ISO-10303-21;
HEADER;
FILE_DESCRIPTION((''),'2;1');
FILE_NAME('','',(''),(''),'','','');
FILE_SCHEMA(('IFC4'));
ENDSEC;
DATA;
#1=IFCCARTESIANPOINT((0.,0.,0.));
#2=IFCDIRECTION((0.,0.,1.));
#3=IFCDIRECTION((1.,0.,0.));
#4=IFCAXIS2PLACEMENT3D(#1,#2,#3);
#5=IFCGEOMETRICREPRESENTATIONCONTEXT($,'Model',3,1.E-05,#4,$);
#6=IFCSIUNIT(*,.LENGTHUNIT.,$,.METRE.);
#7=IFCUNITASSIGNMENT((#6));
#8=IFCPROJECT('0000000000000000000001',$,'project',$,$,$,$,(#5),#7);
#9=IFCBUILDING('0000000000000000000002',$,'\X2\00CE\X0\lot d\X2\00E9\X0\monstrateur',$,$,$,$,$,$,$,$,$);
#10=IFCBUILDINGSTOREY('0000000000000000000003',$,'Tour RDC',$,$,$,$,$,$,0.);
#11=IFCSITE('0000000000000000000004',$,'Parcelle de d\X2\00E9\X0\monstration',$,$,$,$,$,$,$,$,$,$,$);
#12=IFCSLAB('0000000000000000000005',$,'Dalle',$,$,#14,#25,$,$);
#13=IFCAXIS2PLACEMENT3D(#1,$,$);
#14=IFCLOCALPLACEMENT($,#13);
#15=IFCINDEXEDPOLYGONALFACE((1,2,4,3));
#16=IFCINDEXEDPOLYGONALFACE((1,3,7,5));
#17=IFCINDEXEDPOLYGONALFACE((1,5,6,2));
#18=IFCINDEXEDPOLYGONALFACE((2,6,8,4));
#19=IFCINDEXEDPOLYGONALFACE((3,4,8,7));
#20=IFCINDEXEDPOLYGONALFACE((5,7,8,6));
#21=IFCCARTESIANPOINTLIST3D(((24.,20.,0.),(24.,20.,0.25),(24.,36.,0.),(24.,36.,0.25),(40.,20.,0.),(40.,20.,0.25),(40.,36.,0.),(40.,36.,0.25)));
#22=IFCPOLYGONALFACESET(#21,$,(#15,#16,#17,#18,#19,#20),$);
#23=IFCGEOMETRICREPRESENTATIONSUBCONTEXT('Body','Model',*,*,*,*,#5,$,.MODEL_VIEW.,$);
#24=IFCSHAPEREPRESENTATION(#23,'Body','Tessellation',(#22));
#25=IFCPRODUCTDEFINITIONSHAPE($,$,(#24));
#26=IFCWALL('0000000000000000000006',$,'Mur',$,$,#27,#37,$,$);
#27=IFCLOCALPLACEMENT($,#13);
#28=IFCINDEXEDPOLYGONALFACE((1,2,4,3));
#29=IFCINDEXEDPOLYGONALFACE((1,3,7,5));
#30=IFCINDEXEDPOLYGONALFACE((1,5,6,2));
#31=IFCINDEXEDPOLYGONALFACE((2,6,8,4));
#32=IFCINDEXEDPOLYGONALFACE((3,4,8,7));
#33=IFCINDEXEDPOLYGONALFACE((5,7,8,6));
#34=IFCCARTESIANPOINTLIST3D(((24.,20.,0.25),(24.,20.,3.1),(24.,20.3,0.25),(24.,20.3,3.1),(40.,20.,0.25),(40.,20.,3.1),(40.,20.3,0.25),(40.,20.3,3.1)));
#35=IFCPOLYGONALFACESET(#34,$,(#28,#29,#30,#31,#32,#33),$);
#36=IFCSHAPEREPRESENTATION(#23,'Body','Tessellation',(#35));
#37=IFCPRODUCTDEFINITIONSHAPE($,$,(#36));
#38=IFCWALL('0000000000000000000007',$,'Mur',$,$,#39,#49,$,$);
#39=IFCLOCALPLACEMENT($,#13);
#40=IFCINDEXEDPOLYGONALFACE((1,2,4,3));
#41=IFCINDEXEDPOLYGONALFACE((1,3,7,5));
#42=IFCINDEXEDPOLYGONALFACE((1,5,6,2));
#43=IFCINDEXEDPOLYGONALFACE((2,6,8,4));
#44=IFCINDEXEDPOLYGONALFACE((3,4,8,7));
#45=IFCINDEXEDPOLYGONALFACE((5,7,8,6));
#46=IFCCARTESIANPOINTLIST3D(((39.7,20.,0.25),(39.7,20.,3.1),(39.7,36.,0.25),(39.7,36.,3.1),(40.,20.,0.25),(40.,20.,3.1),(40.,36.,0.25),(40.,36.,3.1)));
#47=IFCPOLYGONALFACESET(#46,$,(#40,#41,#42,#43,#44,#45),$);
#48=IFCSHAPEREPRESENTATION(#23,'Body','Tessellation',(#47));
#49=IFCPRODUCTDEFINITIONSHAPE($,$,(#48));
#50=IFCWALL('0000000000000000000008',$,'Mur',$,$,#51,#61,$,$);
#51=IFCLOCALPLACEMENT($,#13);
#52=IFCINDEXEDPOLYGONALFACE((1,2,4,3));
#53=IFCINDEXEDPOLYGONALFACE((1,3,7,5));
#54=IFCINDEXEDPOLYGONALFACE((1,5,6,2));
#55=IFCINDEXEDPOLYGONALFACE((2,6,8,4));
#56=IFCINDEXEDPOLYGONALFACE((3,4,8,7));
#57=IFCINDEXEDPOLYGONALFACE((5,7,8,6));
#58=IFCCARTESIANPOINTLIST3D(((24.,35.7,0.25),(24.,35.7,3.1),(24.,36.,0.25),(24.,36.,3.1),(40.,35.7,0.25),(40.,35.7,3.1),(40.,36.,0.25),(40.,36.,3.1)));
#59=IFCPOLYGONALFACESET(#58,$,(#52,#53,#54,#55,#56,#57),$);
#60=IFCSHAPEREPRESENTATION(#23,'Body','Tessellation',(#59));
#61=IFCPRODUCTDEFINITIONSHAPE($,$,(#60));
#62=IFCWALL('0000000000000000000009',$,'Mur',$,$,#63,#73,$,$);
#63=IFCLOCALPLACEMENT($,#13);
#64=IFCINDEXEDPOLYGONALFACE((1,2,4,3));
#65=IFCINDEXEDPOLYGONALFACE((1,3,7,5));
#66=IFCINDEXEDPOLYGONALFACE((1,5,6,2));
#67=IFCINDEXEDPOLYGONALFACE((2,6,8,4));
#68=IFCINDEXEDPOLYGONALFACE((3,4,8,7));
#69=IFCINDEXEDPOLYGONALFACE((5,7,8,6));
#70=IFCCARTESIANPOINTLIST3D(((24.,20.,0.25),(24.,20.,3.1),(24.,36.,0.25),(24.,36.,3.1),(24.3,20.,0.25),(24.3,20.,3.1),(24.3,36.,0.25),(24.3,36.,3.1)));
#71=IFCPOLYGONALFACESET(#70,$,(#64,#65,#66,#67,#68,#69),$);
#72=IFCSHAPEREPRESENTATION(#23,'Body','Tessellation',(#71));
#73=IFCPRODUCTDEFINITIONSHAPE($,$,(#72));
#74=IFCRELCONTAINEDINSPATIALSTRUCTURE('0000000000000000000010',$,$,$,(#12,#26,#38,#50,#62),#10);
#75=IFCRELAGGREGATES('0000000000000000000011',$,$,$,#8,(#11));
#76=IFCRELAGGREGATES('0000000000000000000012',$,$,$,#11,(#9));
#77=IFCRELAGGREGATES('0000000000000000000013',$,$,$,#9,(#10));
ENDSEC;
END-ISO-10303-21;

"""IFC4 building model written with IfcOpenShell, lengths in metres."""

from ifc_helpers import new_model, si_unit, frame, origin_with_axes, place, context, subcontext, project, spatial, indexed_curve, outline, extrude, element, save


model = new_model("IFC4")

# Units and contexts
model_context = context("Model", 3, precision=1e-05, world=origin_with_axes())
body_context = subcontext(model_context, "Body", "Model", "MODEL_VIEW")
ifc_project = project(units=[si_unit("LENGTHUNIT", "METRE")], contexts=[model_context])

# Site, building, storey
site = spatial("IfcSite", under=ifc_project, Name="Parcelle de démonstration")
building = spatial("IfcBuilding", under=site, Name="Îlot démonstrateur")
storey = spatial("IfcBuildingStorey", under=building, Name="Tour RDC", Elevation=0.0)

# Slab
slab_placement = place(None, origin_with_axes())
element("IfcSlab", 1, at=slab_placement, inside=storey, Name="Dalle", context=body_context, shape_type="SweptSolid", body=[
    extrude(outline(indexed_curve([(24.0, 20.0), (40.0, 20.0), (40.0, 36.0), (24.0, 36.0)])), None, (0.0, 0.0, 1.0), 0.25),
])

# Walls
for number, where, z_axis, x_axis, name in (
    (2, (24.0, 20.0, 0.25), (0.0, 0.0, 1.0), (1.0, 0.0, 0.0), "Mur"),
    (3, (40.0, 20.0, 0.25), (0.0, 0.0, 1.0), (0.0, 1.0, 0.0), "Mur"),
    (4, (40.0, 36.0, 0.25), (0.0, 0.0, 1.0), (-1.0, 0.0, 0.0), "Mur"),
    (5, (24.0, 36.0, 0.25), (0.0, 0.0, 1.0), (0.0, -1.0, 0.0), "Mur"),
):
    element("IfcWall", number, at=place(None, frame(where, z_axis=z_axis, x_axis=x_axis)), inside=storey, Name=name, context=body_context, shape_type="SweptSolid", body=[
        extrude(outline(indexed_curve([(0.0, 0.0), (0.0, 0.3), (16.0, 0.3), (16.0, 0.0), (0.0, 0.0)], self_intersect=False)), origin_with_axes(), (0.0, 0.0, 1.0), 2.85),
    ])

save(model, "model.ifc")
